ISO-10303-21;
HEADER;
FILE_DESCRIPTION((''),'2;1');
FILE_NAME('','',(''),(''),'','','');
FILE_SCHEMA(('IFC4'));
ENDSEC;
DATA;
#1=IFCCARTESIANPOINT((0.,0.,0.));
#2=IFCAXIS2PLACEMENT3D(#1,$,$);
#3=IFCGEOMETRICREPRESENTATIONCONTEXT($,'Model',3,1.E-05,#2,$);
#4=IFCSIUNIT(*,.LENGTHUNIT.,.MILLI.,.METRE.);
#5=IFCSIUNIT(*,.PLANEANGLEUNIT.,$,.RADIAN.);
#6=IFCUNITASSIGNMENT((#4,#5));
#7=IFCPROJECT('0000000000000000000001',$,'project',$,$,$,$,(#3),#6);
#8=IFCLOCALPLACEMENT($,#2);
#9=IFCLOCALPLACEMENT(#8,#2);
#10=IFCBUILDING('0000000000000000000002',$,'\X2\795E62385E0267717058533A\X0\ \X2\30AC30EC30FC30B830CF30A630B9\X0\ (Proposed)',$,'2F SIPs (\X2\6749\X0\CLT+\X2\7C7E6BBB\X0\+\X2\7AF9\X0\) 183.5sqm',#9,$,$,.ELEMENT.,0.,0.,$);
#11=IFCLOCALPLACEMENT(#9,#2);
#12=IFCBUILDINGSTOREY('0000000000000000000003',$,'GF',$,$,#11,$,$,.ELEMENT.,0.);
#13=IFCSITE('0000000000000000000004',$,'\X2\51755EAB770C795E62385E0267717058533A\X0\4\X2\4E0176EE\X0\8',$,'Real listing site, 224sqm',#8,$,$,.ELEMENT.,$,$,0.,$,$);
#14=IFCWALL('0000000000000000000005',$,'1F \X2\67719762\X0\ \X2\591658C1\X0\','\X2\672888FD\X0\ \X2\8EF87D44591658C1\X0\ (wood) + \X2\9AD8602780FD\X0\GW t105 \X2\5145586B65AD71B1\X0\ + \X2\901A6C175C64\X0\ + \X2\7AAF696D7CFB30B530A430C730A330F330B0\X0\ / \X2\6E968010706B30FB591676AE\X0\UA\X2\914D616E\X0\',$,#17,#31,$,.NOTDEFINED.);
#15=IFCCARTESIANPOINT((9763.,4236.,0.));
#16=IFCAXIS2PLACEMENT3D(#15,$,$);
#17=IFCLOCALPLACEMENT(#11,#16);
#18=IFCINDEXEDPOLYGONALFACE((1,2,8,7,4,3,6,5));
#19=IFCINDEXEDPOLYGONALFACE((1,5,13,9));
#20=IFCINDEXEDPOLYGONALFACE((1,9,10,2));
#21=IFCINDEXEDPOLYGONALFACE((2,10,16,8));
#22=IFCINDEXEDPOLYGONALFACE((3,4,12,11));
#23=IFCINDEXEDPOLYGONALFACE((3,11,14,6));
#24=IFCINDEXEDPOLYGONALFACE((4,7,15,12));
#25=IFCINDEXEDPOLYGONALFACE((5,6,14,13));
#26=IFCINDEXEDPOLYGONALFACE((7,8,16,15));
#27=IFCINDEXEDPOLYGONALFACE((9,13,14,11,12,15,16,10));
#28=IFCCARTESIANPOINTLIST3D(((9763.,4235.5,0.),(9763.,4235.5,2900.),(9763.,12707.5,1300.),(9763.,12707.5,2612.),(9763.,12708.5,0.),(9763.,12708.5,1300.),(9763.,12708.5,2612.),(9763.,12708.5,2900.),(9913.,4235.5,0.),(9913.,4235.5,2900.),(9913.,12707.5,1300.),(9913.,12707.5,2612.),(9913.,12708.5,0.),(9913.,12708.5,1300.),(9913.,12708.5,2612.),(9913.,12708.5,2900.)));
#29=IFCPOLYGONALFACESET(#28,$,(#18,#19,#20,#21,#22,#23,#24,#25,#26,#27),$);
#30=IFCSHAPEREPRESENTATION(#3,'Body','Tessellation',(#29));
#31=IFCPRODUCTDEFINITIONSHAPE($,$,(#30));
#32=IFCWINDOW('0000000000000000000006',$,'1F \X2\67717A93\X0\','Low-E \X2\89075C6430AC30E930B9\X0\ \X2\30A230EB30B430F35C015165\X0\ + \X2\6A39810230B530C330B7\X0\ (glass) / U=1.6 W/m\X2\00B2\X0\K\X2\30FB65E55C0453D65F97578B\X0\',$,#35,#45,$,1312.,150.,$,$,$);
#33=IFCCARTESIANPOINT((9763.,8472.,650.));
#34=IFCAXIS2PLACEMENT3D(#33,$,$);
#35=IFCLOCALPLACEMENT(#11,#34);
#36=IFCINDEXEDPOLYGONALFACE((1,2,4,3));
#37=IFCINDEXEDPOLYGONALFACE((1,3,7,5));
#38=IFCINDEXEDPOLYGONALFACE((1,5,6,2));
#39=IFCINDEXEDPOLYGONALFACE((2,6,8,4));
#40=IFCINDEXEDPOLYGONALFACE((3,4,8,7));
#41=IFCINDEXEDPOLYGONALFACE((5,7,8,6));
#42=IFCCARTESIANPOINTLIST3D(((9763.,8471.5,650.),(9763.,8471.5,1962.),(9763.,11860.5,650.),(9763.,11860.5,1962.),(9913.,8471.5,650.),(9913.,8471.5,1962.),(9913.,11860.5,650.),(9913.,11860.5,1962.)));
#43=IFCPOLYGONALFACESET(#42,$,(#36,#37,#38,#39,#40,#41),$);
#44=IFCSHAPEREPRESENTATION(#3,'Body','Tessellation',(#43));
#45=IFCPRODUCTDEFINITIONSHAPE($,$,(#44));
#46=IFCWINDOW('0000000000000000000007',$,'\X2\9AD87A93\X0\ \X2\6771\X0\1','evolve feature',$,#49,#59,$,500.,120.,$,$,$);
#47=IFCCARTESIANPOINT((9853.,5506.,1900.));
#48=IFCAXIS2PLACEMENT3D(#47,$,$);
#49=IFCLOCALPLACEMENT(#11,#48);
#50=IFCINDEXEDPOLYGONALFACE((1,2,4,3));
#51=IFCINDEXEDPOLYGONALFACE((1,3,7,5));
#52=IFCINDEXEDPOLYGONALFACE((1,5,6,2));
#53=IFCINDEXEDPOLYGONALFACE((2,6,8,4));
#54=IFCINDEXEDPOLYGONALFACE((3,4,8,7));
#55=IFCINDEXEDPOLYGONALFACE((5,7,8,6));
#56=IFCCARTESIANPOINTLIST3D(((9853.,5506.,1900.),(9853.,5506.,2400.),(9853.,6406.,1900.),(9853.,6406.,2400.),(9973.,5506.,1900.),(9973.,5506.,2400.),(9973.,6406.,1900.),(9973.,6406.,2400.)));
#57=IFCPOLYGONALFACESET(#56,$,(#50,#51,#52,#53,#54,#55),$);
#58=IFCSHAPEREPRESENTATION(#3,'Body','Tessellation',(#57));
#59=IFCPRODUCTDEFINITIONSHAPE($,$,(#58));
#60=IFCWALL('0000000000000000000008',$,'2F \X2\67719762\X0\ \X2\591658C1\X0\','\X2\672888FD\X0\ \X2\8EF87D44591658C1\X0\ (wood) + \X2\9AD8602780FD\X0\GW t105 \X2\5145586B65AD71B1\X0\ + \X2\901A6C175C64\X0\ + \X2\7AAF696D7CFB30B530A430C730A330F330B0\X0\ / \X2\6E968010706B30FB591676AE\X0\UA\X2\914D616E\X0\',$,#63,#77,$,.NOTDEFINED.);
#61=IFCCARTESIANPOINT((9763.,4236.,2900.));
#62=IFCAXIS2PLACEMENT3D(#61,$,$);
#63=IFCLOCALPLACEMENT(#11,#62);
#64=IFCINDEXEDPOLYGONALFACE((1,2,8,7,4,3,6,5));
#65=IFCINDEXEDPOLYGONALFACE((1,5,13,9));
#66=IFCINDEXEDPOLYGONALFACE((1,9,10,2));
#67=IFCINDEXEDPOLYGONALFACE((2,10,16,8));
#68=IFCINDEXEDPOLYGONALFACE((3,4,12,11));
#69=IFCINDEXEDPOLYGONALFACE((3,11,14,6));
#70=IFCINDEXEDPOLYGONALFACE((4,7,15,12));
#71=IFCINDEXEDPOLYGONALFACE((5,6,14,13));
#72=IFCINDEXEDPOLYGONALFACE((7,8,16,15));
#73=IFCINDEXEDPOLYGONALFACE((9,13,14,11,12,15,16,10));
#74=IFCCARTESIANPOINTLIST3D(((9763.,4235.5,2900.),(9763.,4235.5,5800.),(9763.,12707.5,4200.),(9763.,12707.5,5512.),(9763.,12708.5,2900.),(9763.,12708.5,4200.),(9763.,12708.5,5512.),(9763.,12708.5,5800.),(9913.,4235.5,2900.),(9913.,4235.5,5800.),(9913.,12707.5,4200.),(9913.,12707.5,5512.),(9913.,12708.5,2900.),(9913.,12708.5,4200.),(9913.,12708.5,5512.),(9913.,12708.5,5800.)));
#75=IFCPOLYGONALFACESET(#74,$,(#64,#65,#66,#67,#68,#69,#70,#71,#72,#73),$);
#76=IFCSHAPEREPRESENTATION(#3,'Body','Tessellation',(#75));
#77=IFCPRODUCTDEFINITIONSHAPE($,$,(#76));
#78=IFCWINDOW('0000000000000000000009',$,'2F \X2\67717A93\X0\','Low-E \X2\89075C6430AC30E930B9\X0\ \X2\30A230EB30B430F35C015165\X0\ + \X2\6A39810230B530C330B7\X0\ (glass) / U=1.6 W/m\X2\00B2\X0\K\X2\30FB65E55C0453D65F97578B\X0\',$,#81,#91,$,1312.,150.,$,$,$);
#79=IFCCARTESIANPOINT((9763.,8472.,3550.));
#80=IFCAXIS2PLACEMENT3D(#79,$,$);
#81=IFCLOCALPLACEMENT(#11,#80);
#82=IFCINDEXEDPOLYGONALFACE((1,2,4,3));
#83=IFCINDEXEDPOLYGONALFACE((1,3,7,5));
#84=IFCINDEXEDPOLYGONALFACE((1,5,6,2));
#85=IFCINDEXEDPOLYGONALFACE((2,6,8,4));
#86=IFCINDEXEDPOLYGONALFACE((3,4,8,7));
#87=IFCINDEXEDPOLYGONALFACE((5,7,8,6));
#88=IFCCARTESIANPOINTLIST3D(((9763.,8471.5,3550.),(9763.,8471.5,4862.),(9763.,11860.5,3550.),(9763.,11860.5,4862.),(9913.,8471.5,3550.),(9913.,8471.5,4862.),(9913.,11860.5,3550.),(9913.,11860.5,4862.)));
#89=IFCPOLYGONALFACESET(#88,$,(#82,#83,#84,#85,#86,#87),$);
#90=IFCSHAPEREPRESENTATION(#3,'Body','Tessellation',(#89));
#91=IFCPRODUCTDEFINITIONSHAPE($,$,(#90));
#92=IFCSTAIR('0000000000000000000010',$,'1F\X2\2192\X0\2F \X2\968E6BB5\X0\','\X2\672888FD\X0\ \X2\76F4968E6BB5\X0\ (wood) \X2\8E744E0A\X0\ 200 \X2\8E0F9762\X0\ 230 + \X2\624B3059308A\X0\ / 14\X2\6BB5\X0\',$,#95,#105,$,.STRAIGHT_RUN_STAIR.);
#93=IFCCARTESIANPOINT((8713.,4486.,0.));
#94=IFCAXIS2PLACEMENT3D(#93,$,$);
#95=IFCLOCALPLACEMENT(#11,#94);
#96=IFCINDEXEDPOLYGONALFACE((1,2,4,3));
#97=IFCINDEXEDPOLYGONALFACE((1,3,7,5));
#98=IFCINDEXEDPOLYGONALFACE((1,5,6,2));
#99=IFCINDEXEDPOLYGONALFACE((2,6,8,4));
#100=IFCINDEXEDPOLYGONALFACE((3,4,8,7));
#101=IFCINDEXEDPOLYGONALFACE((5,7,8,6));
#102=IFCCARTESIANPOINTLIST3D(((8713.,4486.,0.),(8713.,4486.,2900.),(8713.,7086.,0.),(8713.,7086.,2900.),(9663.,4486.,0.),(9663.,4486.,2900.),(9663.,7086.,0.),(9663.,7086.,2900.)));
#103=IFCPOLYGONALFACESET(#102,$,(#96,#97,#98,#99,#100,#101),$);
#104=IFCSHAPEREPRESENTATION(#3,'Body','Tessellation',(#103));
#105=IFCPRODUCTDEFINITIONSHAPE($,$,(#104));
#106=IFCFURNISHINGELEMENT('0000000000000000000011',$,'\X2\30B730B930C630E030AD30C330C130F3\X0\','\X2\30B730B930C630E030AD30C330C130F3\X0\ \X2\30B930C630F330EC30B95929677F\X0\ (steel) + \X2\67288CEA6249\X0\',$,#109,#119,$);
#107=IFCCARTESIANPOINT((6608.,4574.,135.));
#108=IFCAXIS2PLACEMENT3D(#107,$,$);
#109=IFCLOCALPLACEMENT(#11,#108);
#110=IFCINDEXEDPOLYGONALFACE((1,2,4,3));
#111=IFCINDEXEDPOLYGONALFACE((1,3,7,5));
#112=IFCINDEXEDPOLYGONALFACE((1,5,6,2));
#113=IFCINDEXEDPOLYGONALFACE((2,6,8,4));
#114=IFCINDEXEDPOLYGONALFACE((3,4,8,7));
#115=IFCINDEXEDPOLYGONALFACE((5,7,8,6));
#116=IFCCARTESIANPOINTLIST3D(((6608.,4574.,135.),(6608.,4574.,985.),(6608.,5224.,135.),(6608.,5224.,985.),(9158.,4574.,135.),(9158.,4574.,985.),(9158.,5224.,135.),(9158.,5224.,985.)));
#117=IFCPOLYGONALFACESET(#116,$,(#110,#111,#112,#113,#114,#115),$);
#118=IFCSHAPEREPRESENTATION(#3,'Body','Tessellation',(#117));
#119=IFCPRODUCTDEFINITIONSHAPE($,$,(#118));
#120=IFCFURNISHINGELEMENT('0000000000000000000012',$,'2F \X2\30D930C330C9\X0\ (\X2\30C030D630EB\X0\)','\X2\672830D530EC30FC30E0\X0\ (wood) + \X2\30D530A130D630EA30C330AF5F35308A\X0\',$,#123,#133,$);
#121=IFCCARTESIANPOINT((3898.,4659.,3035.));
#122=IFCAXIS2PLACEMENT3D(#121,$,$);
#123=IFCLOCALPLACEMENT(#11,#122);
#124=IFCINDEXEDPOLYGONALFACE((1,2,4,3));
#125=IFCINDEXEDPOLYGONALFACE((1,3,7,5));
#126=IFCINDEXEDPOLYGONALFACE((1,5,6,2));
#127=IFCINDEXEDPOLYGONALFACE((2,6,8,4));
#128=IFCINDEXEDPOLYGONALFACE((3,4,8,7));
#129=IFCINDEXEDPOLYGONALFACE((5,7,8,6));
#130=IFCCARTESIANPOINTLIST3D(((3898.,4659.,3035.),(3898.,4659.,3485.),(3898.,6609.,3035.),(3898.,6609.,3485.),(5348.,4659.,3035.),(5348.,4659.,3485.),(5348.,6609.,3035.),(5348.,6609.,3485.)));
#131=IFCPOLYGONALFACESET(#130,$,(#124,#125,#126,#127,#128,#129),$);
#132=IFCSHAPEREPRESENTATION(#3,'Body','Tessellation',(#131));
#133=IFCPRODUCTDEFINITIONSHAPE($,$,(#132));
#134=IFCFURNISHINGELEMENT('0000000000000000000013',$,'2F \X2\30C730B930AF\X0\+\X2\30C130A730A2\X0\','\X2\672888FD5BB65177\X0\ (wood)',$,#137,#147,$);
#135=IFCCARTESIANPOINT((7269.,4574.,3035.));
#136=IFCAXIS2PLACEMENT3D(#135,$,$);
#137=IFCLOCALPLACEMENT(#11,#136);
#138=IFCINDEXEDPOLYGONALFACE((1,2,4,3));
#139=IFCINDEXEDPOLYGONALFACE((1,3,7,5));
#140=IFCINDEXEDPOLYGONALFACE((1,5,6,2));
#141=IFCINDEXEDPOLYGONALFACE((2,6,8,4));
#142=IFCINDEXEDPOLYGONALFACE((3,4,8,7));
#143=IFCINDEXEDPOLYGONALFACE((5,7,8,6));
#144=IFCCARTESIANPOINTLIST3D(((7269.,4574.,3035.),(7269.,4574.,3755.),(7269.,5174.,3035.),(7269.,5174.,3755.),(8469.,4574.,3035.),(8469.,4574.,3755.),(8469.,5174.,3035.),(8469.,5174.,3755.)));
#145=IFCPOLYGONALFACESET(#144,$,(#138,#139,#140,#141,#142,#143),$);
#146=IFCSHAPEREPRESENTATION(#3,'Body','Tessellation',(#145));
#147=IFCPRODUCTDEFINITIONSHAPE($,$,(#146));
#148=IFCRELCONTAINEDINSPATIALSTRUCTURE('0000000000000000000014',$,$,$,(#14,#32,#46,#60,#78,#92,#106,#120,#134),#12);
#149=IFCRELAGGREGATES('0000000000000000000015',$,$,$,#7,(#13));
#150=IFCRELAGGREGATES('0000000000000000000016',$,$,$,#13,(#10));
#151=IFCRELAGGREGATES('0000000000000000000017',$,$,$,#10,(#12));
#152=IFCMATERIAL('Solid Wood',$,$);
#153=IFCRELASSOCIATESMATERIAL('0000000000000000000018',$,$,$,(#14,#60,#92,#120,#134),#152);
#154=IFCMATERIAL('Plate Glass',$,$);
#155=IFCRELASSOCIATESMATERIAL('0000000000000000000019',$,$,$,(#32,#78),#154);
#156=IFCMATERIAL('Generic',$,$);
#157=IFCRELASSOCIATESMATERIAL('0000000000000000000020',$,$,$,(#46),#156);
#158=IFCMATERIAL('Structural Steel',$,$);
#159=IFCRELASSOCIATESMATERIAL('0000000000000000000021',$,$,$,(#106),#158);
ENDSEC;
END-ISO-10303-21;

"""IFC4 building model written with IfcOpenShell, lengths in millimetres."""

from ifc_helpers import new_model, si_unit, frame, frame_2d, origin, place, context, project, spatial, rectangle, extrude, material, element, fill, save


model = new_model("IFC4")

# Units and contexts
model_context = context("Model", 3, precision=1e-05, world=origin())
ifc_project = project(units=[si_unit("LENGTHUNIT", "METRE", prefix="MILLI"), si_unit("PLANEANGLEUNIT", "RADIAN")], contexts=[model_context])

# Site, building, storey
site_placement = place(None, origin())
site = spatial("IfcSite", under=ifc_project, at=site_placement, Name="兵庫県神戸市東灘区4丁目8", ObjectType="Real listing site, 224sqm", CompositionType="ELEMENT", RefElevation=0.0)
building_placement = place(site_placement, origin())
building = spatial("IfcBuilding", under=site, at=building_placement, Name="神戸市東灘区 ガレージハウス (Proposed)", ObjectType="2F SIPs (杉CLT+籾殻+竹) 183.5sqm", CompositionType="ELEMENT", ElevationOfRefHeight=0.0, ElevationOfTerrain=0.0)
storey_placement = place(building_placement, origin())
storey = spatial("IfcBuildingStorey", under=building, at=storey_placement, Name="GF", CompositionType="ELEMENT", Elevation=0.0)

# Shared definitions
ifc_material_1 = material(Name="Solid Wood")

# Wall, openings, windows
wall_1_placement = place(storey_placement, frame((9763.0, 4236.0, 0.0)))
wall_1 = element("IfcWall", 1, at=wall_1_placement, inside=storey, material=ifc_material_1, Name="1F 東面 外壁", Description="木製 軸組外壁 (wood) + 高性能GW t105 充填断熱 + 通気層 + 窯業系サイディング / 準耐火・外皮UA配慮", PredefinedType="NOTDEFINED", context=model_context, shape_type="SweptSolid", body=[
    extrude(rectangle(XDim=150.0, YDim=8473.0, at=frame_2d((75.0, 4236.0))), frame((9763.0, 4236.0, 0.0)), (0.0, 0.0, 1.0), 2900.0),
])
opening_1_placement = place(storey_placement, frame((9763.0, 8472.0, 650.0)))
opening_1 = element("IfcOpeningElement", 2, at=opening_1_placement, cuts=wall_1, PredefinedType="NOTDEFINED", context=model_context, shape_type="SweptSolid", body=[
    extrude(rectangle(XDim=150.0, YDim=3389.0, at=frame_2d((75.0, 1694.0))), frame((9763.0, 8472.0, 650.0)), (0.0, 0.0, 1.0), 1312.0),
])
opening_2_placement = place(storey_placement, frame((9853.0, 5506.0, 1900.0)))
opening_2 = element("IfcOpeningElement", 3, at=opening_2_placement, cuts=wall_1, PredefinedType="NOTDEFINED", context=model_context, shape_type="SweptSolid", body=[
    extrude(rectangle(XDim=120.0, YDim=900.0, at=frame_2d((60.0, 450.0))), frame((9853.0, 5506.0, 1900.0)), (0.0, 0.0, 1.0), 500.0),
])
ifc_material_2 = material(Name="Plate Glass")
window_1_placement = place(storey_placement, frame((9763.0, 8472.0, 650.0)))
window_1 = element("IfcWindow", 4, at=window_1_placement, inside=storey, material=ifc_material_2, Name="1F 東窓", Description="Low-E 複層ガラス アルゴン封入 + 樹脂サッシ (glass) / U=1.6 W/m²K・日射取得型", OverallHeight=1312.0, OverallWidth=150.0, context=model_context, shape_type="SweptSolid", body=[
    extrude(rectangle(XDim=150.0, YDim=3389.0, at=frame_2d((75.0, 1694.0))), frame((9763.0, 8472.0, 650.0)), (0.0, 0.0, 1.0), 1312.0),
])
fill(opening_1, window_1)
ifc_material_3 = material(Name="Generic")
window_2_placement = place(storey_placement, frame((9853.0, 5506.0, 1900.0)))
window_2 = element("IfcWindow", 5, at=window_2_placement, inside=storey, material=ifc_material_3, Name="高窓 東1", Description="evolve feature", OverallHeight=500.0, OverallWidth=120.0, context=model_context, shape_type="SweptSolid", body=[
    extrude(rectangle(XDim=120.0, YDim=900.0, at=frame_2d((60.0, 450.0))), frame((9853.0, 5506.0, 1900.0)), (0.0, 0.0, 1.0), 500.0),
])
fill(opening_2, window_2)

# Wall, opening, window
wall_2_placement = place(storey_placement, frame((9763.0, 4236.0, 2900.0)))
wall_2 = element("IfcWall", 6, at=wall_2_placement, inside=storey, material=ifc_material_1, Name="2F 東面 外壁", Description="木製 軸組外壁 (wood) + 高性能GW t105 充填断熱 + 通気層 + 窯業系サイディング / 準耐火・外皮UA配慮", PredefinedType="NOTDEFINED", context=model_context, shape_type="SweptSolid", body=[
    extrude(rectangle(XDim=150.0, YDim=8473.0, at=frame_2d((75.0, 4236.0))), frame((9763.0, 4236.0, 2900.0)), (0.0, 0.0, 1.0), 2900.0),
])
opening_3_placement = place(storey_placement, frame((9763.0, 8472.0, 3550.0)))
opening_3 = element("IfcOpeningElement", 7, at=opening_3_placement, cuts=wall_2, PredefinedType="NOTDEFINED", context=model_context, shape_type="SweptSolid", body=[
    extrude(rectangle(XDim=150.0, YDim=3389.0, at=frame_2d((75.0, 1694.0))), frame((9763.0, 8472.0, 3550.0)), (0.0, 0.0, 1.0), 1312.0),
])
window_3_placement = place(storey_placement, frame((9763.0, 8472.0, 3550.0)))
window_3 = element("IfcWindow", 8, at=window_3_placement, inside=storey, material=ifc_material_2, Name="2F 東窓", Description="Low-E 複層ガラス アルゴン封入 + 樹脂サッシ (glass) / U=1.6 W/m²K・日射取得型", OverallHeight=1312.0, OverallWidth=150.0, context=model_context, shape_type="SweptSolid", body=[
    extrude(rectangle(XDim=150.0, YDim=3389.0, at=frame_2d((75.0, 1694.0))), frame((9763.0, 8472.0, 3550.0)), (0.0, 0.0, 1.0), 1312.0),
])
fill(opening_3, window_3)

# Stair
stair_placement = place(storey_placement, frame((8713.0, 4486.0, 0.0)))
element("IfcStair", 9, at=stair_placement, inside=storey, material=ifc_material_1, Name="1F→2F 階段", Description="木製 直階段 (wood) 蹴上 200 踏面 230 + 手すり / 14段", PredefinedType="STRAIGHT_RUN_STAIR", context=model_context, shape_type="SweptSolid", body=[
    extrude(rectangle(XDim=950.0, YDim=2600.0, at=frame_2d((475.0, 1300.0))), frame((8713.0, 4486.0, 0.0)), (0.0, 0.0, 1.0), 2900.0),
])

# Furnishing elements
ifc_material_4 = material(Name="Structural Steel")
furnishing_1_placement = place(storey_placement, frame((6608.0, 4574.0, 135.0)))
element("IfcFurnishingElement", 10, at=furnishing_1_placement, inside=storey, material=ifc_material_4, Name="システムキッチン", Description="システムキッチン ステンレス天板 (steel) + 木質扉", context=model_context, shape_type="SweptSolid", body=[
    extrude(rectangle(XDim=2550.0, YDim=650.0, at=frame_2d((1275.0, 325.0))), frame((6608.0, 4574.0, 135.0)), (0.0, 0.0, 1.0), 850.0),
])
furnishing_2_placement = place(storey_placement, frame((3898.0, 4659.0, 3035.0)))
element("IfcFurnishingElement", 11, at=furnishing_2_placement, inside=storey, material=ifc_material_1, Name="2F ベッド (ダブル)", Description="木フレーム (wood) + ファブリック張り", context=model_context, shape_type="SweptSolid", body=[
    extrude(rectangle(XDim=1450.0, YDim=1950.0, at=frame_2d((725.0, 975.0))), frame((3898.0, 4659.0, 3035.0)), (0.0, 0.0, 1.0), 450.0),
])
furnishing_3_placement = place(storey_placement, frame((7269.0, 4574.0, 3035.0)))
element("IfcFurnishingElement", 12, at=furnishing_3_placement, inside=storey, material=ifc_material_1, Name="2F デスク+チェア", Description="木製家具 (wood)", context=model_context, shape_type="SweptSolid", body=[
    extrude(rectangle(XDim=1200.0, YDim=600.0, at=frame_2d((600.0, 300.0))), frame((7269.0, 4574.0, 3035.0)), (0.0, 0.0, 1.0), 720.0),
])

save(model, "model.ifc")
